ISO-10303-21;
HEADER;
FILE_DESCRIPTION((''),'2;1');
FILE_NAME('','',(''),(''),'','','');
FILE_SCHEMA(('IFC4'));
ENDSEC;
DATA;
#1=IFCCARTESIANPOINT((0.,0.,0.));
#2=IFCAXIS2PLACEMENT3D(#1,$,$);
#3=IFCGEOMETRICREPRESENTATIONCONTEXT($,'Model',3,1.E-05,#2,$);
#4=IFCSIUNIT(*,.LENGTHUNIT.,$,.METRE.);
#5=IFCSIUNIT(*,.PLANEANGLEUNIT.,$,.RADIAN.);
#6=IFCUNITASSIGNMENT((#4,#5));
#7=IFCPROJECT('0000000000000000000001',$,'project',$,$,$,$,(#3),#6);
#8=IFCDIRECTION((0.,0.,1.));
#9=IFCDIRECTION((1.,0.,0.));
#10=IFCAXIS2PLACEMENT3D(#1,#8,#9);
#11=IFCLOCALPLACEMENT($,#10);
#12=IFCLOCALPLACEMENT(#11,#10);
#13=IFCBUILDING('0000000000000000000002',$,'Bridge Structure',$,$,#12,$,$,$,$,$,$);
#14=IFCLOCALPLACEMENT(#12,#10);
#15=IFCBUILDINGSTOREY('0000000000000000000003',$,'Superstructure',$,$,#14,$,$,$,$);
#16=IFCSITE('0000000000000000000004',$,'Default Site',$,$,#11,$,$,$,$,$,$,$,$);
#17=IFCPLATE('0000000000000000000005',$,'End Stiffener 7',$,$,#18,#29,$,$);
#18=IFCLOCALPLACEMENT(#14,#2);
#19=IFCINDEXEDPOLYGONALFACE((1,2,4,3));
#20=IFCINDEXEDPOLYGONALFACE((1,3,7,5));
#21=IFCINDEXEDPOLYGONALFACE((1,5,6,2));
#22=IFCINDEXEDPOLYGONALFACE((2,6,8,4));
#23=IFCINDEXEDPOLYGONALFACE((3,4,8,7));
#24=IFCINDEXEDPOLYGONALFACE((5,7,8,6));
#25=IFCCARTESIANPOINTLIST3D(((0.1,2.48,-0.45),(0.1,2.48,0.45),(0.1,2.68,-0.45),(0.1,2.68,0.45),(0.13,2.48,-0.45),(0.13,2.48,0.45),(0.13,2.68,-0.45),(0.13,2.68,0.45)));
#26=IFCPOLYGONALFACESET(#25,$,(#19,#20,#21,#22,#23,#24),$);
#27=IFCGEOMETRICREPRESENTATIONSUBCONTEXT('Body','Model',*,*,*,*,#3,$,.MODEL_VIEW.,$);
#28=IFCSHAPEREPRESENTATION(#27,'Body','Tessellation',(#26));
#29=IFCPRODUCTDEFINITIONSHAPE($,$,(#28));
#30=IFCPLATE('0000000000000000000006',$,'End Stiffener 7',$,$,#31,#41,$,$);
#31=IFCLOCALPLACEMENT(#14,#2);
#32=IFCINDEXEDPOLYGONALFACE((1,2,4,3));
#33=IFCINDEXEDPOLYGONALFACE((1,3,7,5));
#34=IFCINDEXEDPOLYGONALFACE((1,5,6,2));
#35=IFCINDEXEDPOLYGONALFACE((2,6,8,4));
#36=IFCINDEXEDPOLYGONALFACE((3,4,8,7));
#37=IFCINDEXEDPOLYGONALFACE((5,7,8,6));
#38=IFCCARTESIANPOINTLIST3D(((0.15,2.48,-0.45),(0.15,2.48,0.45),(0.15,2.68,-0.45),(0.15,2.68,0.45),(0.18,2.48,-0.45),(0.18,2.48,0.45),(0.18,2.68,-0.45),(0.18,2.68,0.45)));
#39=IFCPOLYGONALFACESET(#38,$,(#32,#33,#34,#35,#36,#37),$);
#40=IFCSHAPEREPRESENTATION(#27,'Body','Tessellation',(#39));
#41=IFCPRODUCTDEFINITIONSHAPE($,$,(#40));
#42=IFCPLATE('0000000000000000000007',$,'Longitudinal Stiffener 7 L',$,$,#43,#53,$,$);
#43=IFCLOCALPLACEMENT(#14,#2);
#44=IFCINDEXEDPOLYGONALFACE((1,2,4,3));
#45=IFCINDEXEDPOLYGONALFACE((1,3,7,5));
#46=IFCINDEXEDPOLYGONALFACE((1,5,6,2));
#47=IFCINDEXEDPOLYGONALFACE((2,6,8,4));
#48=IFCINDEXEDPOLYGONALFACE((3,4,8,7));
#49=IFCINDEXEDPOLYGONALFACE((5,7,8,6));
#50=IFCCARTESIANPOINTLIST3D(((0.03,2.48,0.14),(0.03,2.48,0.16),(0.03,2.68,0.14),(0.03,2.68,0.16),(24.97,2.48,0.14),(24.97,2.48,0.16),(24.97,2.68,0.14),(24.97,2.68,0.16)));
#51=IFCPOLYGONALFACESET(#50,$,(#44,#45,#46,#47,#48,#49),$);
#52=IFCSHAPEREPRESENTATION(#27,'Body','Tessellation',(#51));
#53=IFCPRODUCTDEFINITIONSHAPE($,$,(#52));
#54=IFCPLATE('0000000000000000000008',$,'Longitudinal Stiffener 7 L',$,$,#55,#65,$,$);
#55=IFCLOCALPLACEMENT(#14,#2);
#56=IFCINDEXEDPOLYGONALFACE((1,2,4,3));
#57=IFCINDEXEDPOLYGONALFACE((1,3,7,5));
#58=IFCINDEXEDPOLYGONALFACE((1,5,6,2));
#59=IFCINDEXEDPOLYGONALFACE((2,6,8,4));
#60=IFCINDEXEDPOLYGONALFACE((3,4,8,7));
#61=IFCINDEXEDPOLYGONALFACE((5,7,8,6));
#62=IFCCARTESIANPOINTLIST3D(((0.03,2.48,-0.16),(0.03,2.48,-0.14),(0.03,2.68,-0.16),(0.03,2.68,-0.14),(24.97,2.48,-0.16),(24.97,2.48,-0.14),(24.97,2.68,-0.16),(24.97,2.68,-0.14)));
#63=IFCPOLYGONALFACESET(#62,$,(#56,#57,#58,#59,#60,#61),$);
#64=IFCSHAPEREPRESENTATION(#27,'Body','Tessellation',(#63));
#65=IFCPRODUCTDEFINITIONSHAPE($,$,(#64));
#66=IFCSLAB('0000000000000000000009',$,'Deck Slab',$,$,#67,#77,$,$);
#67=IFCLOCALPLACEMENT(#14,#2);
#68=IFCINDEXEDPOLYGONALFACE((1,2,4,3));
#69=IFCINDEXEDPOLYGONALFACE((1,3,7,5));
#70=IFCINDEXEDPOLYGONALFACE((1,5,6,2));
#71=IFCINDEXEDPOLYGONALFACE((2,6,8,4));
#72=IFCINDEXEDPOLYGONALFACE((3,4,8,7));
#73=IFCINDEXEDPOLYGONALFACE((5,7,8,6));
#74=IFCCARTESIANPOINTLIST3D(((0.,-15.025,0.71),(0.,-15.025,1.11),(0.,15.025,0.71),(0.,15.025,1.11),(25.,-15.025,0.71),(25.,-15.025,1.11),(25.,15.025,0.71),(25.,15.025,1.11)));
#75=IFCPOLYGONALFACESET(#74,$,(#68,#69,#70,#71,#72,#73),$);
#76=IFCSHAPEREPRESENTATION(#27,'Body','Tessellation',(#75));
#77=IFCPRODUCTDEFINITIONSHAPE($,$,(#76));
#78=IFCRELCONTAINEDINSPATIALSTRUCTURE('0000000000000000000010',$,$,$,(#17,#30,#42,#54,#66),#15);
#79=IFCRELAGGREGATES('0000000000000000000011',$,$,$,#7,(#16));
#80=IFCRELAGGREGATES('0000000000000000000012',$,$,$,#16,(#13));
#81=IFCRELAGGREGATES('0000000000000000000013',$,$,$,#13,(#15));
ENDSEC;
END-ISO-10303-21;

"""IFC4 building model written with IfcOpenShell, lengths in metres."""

from ifc_helpers import new_model, si_unit, frame, origin, origin_with_axes, origin_2d_with_axis, place, context, subcontext, project, spatial, polyline, rectangle, outline, extrude, element, save


model = new_model("IFC4")

# Units and contexts
model_context = context("Model", 3, precision=1e-05, world=origin())
body_context = subcontext(model_context, "Body", "Model", "MODEL_VIEW")
ifc_project = project(units=[si_unit("LENGTHUNIT", "METRE"), si_unit("PLANEANGLEUNIT", "RADIAN")], contexts=[model_context])

# Site, building, storey
site_placement = place(None, origin_with_axes())
site = spatial("IfcSite", under=ifc_project, at=site_placement, Name="Default Site")
building_placement = place(site_placement, origin_with_axes())
building = spatial("IfcBuilding", under=site, at=building_placement, Name="Bridge Structure")
storey_placement = place(building_placement, origin_with_axes())
storey = spatial("IfcBuildingStorey", under=building, at=storey_placement, Name="Superstructure")

# Plates
for number, where, z_axis, x_axis, name in (
    (1, (0.115, 2.58, -0.45), (0.0, 0.0, 1.0), (1.0, 0.0, 0.0), "End Stiffener 7"),
    (2, (0.165, 2.58, -0.45), (0.0, 0.0, 1.0), (1.0, 0.0, 0.0), "End Stiffener 7"),
):
    element("IfcPlate", number, at=place(storey_placement, frame(where, z_axis=z_axis, x_axis=x_axis)), inside=storey, Name=name, context=body_context, shape_type="SweptSolid", body=[
        extrude(rectangle(XDim=0.03, YDim=0.2, at=origin_2d_with_axis()), origin_with_axes(), (0.0, 0.0, 1.0), 0.9),
    ])
for number, where, z_axis, x_axis, name in (
    (3, (0.03, 2.58, 0.15), (1.0, 0.0, 0.0), (0.0, 1.0, 0.0), "Longitudinal Stiffener 7 L"),
    (4, (0.03, 2.58, -0.15), (1.0, 0.0, 0.0), (0.0, 1.0, 0.0), "Longitudinal Stiffener 7 L"),
):
    element("IfcPlate", number, at=place(storey_placement, frame(where, z_axis=z_axis, x_axis=x_axis)), inside=storey, Name=name, context=body_context, shape_type="SweptSolid", body=[
        extrude(rectangle(XDim=0.2, YDim=0.02, at=origin_2d_with_axis()), origin_with_axes(), (0.0, 0.0, 1.0), 24.94),
    ])

# Slab
slab_placement = place(storey_placement, frame((0.0, 0.0, 0.71), z_axis=(0.0, 0.0, 1.0), x_axis=(1.0, 0.0, 0.0)))
element("IfcSlab", 5, at=slab_placement, inside=storey, Name="Deck Slab", context=body_context, shape_type="SweptSolid", body=[
    extrude(outline(polyline([(0.0, -15.025), (25.0, -15.025), (25.0, 15.025), (0.0, 15.025), (0.0, -15.025)])), origin_with_axes(), (0.0, 0.0, 1.0), 0.4),
])

save(model, "model.ifc")
